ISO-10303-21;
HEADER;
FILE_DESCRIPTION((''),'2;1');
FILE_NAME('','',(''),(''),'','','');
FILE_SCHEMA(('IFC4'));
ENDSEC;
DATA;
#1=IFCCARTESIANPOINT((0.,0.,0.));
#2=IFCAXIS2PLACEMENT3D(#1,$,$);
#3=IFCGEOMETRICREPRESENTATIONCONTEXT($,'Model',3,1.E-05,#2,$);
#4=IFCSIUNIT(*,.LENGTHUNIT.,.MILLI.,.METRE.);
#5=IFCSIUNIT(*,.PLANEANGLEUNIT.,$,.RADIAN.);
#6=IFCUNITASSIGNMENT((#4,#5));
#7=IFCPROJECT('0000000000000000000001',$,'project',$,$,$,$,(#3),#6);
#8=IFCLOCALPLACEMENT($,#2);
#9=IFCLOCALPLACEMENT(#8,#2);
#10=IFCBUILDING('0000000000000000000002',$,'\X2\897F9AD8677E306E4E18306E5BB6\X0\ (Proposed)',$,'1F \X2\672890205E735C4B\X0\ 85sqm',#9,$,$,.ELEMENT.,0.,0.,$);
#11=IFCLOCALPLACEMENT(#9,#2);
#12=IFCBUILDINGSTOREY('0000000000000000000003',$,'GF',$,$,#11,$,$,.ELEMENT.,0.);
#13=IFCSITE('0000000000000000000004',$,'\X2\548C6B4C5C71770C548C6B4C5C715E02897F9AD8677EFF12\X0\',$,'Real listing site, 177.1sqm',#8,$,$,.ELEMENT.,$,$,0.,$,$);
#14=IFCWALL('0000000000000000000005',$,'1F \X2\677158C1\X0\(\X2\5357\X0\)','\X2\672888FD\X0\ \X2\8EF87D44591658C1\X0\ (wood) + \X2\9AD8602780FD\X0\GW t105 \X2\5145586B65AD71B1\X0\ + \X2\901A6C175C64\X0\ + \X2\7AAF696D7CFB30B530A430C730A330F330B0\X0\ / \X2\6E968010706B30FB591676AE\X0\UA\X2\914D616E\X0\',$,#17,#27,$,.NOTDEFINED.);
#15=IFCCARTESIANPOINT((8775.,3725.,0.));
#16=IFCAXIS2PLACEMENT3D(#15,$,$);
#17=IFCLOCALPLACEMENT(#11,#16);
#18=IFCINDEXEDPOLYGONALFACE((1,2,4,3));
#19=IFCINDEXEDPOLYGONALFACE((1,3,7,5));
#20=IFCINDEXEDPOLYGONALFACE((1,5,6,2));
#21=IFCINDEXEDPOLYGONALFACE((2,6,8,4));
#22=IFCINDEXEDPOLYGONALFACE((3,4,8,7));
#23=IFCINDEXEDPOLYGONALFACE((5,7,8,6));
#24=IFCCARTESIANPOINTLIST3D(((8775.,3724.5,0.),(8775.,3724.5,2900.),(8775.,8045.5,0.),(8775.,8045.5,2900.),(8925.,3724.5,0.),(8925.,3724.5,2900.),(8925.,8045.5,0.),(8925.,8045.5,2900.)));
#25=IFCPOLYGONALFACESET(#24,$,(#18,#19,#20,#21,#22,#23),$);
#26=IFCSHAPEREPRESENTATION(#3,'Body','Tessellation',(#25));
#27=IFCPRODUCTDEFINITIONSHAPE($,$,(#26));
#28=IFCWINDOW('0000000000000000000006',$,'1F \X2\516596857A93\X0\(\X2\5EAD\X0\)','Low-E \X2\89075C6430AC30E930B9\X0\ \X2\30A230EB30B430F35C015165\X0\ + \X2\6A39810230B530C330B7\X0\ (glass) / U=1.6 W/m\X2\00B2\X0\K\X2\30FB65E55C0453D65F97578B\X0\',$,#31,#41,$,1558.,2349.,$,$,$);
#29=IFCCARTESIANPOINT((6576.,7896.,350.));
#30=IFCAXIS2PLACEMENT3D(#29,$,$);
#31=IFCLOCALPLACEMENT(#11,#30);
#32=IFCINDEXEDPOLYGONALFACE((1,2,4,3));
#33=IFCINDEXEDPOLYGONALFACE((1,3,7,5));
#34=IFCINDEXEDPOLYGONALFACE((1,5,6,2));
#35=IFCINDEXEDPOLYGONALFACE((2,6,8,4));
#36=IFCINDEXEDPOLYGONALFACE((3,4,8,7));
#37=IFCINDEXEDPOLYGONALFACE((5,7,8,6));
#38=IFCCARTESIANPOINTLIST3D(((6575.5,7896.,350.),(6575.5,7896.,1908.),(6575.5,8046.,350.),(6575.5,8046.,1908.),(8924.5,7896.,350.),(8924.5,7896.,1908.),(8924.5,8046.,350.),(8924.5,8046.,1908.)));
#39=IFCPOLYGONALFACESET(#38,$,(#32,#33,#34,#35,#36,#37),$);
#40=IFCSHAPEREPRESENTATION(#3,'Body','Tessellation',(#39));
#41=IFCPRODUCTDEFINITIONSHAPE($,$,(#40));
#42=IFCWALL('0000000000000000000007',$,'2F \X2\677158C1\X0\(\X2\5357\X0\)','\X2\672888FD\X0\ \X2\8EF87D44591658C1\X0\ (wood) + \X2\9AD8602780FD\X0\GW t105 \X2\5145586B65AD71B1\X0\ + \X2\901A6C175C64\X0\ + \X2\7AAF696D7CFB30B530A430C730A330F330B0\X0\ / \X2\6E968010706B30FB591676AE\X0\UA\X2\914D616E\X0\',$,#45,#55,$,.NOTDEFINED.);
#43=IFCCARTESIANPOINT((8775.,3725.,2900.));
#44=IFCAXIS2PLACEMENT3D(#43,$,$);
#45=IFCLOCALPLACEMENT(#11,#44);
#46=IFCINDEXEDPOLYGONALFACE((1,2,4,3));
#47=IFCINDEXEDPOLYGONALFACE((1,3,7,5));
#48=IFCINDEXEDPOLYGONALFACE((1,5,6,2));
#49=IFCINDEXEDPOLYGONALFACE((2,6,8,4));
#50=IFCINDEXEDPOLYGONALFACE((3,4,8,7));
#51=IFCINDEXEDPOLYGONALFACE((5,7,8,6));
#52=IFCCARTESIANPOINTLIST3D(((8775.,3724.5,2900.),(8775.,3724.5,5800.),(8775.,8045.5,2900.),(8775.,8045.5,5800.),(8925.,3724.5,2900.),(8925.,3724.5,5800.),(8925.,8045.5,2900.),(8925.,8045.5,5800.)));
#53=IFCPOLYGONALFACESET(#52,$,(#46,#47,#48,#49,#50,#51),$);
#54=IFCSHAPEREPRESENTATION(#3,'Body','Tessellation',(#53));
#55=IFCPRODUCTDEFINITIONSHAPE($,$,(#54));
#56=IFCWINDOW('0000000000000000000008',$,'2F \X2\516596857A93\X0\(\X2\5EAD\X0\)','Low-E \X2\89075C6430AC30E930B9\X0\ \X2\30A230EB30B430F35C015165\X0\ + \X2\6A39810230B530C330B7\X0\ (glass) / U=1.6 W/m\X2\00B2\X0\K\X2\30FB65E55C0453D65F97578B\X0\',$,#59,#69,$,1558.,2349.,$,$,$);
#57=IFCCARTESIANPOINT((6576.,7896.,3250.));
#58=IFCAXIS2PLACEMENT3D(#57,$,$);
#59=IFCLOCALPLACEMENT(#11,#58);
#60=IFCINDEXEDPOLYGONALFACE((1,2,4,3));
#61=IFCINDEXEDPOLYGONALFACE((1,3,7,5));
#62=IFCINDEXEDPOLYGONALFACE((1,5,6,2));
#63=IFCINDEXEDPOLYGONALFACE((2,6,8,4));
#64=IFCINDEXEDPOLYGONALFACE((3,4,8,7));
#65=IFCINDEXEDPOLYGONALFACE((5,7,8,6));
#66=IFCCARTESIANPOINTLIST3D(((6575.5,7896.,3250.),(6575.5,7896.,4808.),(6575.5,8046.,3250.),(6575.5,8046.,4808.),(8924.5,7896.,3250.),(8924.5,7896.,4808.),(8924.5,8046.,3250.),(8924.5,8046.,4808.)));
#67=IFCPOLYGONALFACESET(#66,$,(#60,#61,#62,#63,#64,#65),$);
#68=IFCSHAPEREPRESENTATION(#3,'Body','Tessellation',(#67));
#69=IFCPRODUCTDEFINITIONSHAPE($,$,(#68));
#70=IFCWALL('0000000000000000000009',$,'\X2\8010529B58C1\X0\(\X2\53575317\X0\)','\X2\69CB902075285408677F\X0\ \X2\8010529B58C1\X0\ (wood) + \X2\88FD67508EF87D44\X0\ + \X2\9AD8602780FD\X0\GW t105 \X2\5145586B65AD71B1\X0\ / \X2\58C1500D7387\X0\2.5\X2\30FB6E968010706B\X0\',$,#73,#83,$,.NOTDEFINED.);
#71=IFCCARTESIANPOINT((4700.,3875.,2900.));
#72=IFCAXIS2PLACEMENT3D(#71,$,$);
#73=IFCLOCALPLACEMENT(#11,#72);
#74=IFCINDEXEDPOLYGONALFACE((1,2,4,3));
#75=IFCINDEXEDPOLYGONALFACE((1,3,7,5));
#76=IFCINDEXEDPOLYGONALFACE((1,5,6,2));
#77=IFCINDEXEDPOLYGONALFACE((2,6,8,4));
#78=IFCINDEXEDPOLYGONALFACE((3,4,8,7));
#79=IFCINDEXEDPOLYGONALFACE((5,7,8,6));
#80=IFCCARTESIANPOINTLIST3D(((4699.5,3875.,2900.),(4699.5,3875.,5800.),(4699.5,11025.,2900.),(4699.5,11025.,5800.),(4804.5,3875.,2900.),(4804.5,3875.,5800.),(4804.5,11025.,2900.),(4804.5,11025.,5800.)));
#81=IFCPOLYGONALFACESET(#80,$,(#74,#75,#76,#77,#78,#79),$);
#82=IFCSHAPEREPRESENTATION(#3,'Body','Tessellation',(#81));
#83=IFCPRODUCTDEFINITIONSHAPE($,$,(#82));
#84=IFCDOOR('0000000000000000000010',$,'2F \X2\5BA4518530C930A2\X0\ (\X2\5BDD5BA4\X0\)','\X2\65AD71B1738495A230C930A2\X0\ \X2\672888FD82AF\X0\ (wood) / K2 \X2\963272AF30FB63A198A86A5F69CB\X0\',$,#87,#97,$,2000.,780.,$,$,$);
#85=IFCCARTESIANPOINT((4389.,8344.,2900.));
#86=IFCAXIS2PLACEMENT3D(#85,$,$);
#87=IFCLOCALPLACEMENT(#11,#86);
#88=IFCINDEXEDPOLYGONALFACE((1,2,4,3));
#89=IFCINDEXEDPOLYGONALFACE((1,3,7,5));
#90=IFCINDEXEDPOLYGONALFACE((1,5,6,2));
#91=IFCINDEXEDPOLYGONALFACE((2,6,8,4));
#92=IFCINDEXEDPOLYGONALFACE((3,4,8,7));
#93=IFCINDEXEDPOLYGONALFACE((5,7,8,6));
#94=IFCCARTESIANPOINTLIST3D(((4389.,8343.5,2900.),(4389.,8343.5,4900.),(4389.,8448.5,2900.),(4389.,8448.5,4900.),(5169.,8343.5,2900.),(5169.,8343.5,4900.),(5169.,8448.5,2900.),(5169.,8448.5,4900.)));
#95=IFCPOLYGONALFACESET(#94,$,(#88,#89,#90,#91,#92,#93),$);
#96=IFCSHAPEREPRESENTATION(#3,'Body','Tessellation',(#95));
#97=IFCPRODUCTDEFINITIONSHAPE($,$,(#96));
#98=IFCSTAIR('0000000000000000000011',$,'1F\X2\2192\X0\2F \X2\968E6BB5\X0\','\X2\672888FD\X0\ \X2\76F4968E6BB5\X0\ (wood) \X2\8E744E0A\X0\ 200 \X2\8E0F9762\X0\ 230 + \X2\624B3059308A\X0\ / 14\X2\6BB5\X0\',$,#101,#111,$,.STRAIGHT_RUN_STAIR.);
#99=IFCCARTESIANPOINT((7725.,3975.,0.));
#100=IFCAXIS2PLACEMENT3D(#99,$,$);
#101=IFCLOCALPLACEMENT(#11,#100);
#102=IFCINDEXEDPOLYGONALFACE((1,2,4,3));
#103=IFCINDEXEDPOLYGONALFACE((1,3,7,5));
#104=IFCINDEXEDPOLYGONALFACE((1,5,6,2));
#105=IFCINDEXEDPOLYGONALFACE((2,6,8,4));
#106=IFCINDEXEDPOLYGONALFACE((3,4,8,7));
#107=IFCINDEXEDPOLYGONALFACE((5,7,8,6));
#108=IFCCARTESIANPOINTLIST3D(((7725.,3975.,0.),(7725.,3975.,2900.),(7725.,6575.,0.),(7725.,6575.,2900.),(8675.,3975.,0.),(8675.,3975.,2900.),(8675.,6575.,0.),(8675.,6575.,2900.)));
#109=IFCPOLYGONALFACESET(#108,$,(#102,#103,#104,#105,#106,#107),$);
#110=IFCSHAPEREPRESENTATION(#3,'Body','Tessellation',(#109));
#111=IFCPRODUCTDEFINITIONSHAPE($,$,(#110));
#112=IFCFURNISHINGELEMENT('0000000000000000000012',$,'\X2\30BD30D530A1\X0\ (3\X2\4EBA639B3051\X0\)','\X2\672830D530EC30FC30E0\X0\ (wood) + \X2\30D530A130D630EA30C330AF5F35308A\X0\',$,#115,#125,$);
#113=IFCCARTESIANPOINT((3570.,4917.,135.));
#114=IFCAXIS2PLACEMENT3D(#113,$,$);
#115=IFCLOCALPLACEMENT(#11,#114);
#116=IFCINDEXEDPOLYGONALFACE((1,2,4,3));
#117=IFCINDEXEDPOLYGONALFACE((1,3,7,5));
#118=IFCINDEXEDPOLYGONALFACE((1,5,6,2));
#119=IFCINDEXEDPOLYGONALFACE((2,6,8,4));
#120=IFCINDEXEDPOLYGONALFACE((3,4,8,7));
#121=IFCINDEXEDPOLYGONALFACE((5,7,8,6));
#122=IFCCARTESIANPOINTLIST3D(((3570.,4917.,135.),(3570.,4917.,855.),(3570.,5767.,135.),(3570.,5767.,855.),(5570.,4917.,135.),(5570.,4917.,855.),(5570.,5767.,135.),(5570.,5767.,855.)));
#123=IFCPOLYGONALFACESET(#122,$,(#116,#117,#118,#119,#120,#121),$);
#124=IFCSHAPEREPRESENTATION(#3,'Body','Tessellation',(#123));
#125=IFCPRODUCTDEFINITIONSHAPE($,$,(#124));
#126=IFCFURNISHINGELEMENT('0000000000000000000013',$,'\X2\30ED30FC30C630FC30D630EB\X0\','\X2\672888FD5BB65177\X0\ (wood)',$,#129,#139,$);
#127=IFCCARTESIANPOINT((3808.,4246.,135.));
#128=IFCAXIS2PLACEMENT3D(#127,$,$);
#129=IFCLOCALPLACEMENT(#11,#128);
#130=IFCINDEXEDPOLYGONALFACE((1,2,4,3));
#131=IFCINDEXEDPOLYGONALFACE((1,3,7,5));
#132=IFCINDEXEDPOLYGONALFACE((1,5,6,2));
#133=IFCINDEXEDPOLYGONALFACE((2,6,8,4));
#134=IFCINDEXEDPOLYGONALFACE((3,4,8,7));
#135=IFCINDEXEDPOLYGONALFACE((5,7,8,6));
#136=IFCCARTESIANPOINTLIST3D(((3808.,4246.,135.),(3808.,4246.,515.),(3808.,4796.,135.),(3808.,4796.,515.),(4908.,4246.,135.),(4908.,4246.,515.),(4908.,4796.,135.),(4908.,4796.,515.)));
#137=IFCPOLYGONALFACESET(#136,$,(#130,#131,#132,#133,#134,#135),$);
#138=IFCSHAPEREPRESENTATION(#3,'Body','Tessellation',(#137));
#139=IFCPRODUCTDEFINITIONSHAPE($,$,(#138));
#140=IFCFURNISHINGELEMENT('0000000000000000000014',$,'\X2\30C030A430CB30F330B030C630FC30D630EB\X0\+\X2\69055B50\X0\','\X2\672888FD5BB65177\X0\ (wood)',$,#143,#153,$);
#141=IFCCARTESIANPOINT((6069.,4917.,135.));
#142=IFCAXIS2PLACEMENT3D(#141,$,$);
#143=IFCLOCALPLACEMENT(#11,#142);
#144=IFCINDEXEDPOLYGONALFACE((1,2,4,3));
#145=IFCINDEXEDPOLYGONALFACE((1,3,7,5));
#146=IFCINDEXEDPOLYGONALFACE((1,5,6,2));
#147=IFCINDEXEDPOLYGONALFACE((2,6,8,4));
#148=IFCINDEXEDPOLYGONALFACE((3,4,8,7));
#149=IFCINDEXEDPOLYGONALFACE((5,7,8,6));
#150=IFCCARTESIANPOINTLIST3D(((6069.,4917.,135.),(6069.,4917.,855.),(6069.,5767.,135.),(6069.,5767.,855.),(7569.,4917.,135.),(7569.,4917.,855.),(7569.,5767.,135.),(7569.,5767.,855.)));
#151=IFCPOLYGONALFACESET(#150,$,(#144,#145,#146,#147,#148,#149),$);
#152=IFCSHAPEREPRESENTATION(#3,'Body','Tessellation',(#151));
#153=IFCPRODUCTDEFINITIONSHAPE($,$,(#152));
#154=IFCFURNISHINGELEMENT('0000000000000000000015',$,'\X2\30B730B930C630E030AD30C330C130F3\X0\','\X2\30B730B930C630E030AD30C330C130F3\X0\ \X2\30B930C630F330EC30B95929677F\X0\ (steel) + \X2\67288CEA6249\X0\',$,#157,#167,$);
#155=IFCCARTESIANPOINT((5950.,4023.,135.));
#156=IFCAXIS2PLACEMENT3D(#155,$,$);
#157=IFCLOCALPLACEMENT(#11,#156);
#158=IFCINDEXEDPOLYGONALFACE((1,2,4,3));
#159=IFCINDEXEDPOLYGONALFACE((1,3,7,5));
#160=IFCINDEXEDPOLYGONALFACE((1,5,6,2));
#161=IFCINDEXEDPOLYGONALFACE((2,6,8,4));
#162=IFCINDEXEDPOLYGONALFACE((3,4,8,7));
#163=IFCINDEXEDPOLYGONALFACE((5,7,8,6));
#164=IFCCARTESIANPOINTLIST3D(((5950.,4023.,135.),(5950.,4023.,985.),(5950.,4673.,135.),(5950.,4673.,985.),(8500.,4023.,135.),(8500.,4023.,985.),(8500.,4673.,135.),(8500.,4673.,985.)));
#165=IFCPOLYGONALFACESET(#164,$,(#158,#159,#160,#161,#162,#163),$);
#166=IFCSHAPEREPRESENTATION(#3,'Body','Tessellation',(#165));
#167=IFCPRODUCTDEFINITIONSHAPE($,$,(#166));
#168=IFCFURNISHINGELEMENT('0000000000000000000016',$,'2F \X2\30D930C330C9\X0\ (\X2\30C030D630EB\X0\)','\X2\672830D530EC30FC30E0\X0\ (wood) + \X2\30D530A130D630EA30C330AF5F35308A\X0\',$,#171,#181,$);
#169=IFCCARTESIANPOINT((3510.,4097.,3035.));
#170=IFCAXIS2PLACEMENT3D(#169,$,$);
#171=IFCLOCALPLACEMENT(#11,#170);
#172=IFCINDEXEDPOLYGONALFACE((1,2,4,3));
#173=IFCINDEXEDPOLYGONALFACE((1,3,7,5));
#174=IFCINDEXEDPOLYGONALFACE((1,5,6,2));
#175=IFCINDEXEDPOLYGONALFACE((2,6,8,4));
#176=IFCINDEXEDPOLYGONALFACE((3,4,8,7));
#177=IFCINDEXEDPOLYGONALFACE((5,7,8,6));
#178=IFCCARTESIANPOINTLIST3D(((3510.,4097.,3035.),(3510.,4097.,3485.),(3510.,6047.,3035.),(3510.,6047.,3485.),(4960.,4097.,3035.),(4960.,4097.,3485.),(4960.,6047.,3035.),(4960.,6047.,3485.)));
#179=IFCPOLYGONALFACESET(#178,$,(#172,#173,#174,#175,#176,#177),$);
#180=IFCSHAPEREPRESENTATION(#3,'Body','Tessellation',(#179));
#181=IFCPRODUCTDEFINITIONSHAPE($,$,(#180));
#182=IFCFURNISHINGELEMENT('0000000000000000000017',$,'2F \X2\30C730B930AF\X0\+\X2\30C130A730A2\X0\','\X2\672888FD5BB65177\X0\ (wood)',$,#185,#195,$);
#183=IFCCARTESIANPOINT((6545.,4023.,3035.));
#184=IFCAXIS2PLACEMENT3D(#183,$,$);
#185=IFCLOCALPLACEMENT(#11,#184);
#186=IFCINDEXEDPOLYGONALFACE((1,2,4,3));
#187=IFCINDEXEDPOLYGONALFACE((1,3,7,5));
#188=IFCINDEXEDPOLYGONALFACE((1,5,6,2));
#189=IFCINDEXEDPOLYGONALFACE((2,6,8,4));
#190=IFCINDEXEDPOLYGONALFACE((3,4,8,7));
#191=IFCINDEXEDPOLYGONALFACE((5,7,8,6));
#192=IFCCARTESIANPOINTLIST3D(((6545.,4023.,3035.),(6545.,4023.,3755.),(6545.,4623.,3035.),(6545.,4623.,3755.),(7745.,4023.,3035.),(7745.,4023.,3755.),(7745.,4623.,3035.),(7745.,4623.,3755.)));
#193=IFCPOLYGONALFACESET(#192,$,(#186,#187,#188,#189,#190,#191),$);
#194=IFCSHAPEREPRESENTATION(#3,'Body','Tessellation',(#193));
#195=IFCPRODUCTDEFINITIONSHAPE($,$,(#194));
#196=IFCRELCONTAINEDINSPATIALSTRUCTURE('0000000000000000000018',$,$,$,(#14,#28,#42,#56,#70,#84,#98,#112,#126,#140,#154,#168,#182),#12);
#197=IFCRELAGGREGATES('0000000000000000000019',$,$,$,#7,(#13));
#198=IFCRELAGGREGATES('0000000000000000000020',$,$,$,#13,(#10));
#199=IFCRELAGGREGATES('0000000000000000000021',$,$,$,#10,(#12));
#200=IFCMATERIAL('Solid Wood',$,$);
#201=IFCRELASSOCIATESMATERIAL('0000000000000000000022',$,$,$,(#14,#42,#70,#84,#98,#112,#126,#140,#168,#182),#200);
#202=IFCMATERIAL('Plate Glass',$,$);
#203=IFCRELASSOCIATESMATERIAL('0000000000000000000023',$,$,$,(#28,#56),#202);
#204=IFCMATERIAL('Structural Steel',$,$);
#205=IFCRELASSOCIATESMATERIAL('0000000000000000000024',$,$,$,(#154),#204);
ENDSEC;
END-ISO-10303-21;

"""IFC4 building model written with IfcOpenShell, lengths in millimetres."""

from ifc_helpers import new_model, si_unit, frame, frame_2d, origin, place, context, project, spatial, rectangle, extrude, material, element, fill, save


model = new_model("IFC4")

# Units and contexts
model_context = context("Model", 3, precision=1e-05, world=origin())
ifc_project = project(units=[si_unit("LENGTHUNIT", "METRE", prefix="MILLI"), si_unit("PLANEANGLEUNIT", "RADIAN")], contexts=[model_context])

# Site, building, storey
site_placement = place(None, origin())
site = spatial("IfcSite", under=ifc_project, at=site_placement, Name="和歌山県和歌山市西高松２", ObjectType="Real listing site, 177.1sqm", CompositionType="ELEMENT", RefElevation=0.0)
building_placement = place(site_placement, origin())
building = spatial("IfcBuilding", under=site, at=building_placement, Name="西高松の丘の家 (Proposed)", ObjectType="1F 木造平屋 85sqm", CompositionType="ELEMENT", ElevationOfRefHeight=0.0, ElevationOfTerrain=0.0)
storey_placement = place(building_placement, origin())
storey = spatial("IfcBuildingStorey", under=building, at=storey_placement, Name="GF", CompositionType="ELEMENT", Elevation=0.0)

# Wall, opening, window
ifc_material_1 = material(Name="Solid Wood")
wall_1_placement = place(storey_placement, frame((8775.0, 3725.0, 0.0)))
wall_1 = element("IfcWall", 1, at=wall_1_placement, inside=storey, material=ifc_material_1, Name="1F 東壁(南)", Description="木製 軸組外壁 (wood) + 高性能GW t105 充填断熱 + 通気層 + 窯業系サイディング / 準耐火・外皮UA配慮", PredefinedType="NOTDEFINED", context=model_context, shape_type="SweptSolid", body=[
    extrude(rectangle(XDim=150.0, YDim=4321.0, at=frame_2d((75.0, 2160.0))), frame((8775.0, 3725.0, 0.0)), (0.0, 0.0, 1.0), 2900.0),
])
opening_1_placement = place(storey_placement, frame((6576.0, 7896.0, 350.0)))
opening_1 = element("IfcOpeningElement", 2, at=opening_1_placement, cuts=wall_1, PredefinedType="NOTDEFINED", context=model_context, shape_type="SweptSolid", body=[
    extrude(rectangle(XDim=2349.0, YDim=150.0, at=frame_2d((1174.0, 75.0))), frame((6576.0, 7896.0, 350.0)), (0.0, 0.0, 1.0), 1558.0),
])
ifc_material_2 = material(Name="Plate Glass")
window_1_placement = place(storey_placement, frame((6576.0, 7896.0, 350.0)))
window_1 = element("IfcWindow", 3, at=window_1_placement, inside=storey, material=ifc_material_2, Name="1F 入隅窓(庭)", Description="Low-E 複層ガラス アルゴン封入 + 樹脂サッシ (glass) / U=1.6 W/m²K・日射取得型", OverallHeight=1558.0, OverallWidth=2349.0, context=model_context, shape_type="SweptSolid", body=[
    extrude(rectangle(XDim=2349.0, YDim=150.0, at=frame_2d((1174.0, 75.0))), frame((6576.0, 7896.0, 350.0)), (0.0, 0.0, 1.0), 1558.0),
])
fill(opening_1, window_1)

# Wall, opening, window
wall_2_placement = place(storey_placement, frame((8775.0, 3725.0, 2900.0)))
wall_2 = element("IfcWall", 4, at=wall_2_placement, inside=storey, material=ifc_material_1, Name="2F 東壁(南)", Description="木製 軸組外壁 (wood) + 高性能GW t105 充填断熱 + 通気層 + 窯業系サイディング / 準耐火・外皮UA配慮", PredefinedType="NOTDEFINED", context=model_context, shape_type="SweptSolid", body=[
    extrude(rectangle(XDim=150.0, YDim=4321.0, at=frame_2d((75.0, 2160.0))), frame((8775.0, 3725.0, 2900.0)), (0.0, 0.0, 1.0), 2900.0),
])
opening_2_placement = place(storey_placement, frame((6576.0, 7896.0, 3250.0)))
opening_2 = element("IfcOpeningElement", 5, at=opening_2_placement, cuts=wall_2, PredefinedType="NOTDEFINED", context=model_context, shape_type="SweptSolid", body=[
    extrude(rectangle(XDim=2349.0, YDim=150.0, at=frame_2d((1174.0, 75.0))), frame((6576.0, 7896.0, 3250.0)), (0.0, 0.0, 1.0), 1558.0),
])
window_2_placement = place(storey_placement, frame((6576.0, 7896.0, 3250.0)))
window_2 = element("IfcWindow", 6, at=window_2_placement, inside=storey, material=ifc_material_2, Name="2F 入隅窓(庭)", Description="Low-E 複層ガラス アルゴン封入 + 樹脂サッシ (glass) / U=1.6 W/m²K・日射取得型", OverallHeight=1558.0, OverallWidth=2349.0, context=model_context, shape_type="SweptSolid", body=[
    extrude(rectangle(XDim=2349.0, YDim=150.0, at=frame_2d((1174.0, 75.0))), frame((6576.0, 7896.0, 3250.0)), (0.0, 0.0, 1.0), 1558.0),
])
fill(opening_2, window_2)

# Wall, opening, door
wall_3_placement = place(storey_placement, frame((4700.0, 3875.0, 2900.0)))
wall_3 = element("IfcWall", 7, at=wall_3_placement, inside=storey, material=ifc_material_1, Name="耐力壁(南北)", Description="構造用合板 耐力壁 (wood) + 製材軸組 + 高性能GW t105 充填断熱 / 壁倍率2.5・準耐火", PredefinedType="NOTDEFINED", context=model_context, shape_type="SweptSolid", body=[
    extrude(rectangle(XDim=105.0, YDim=7150.0, at=frame_2d((52.0, 3575.0))), frame((4700.0, 3875.0, 2900.0)), (0.0, 0.0, 1.0), 2900.0),
])
opening_3_placement = place(storey_placement, frame((4389.0, 8344.0, 2900.0)))
opening_3 = element("IfcOpeningElement", 8, at=opening_3_placement, cuts=wall_3, PredefinedType="NOTDEFINED", context=model_context, shape_type="SweptSolid", body=[
    extrude(rectangle(XDim=780.0, YDim=105.0, at=frame_2d((390.0, 52.0))), frame((4389.0, 8344.0, 2900.0)), (0.0, 0.0, 1.0), 2000.0),
])
door_1_placement = place(storey_placement, frame((4389.0, 8344.0, 2900.0)))
door_1 = element("IfcDoor", 9, at=door_1_placement, inside=storey, material=ifc_material_1, Name="2F 室内ドア (寝室)", Description="断熱玄関ドア 木製芯 (wood) / K2 防犯・採風機構", OverallHeight=2000.0, OverallWidth=780.0, context=model_context, shape_type="SweptSolid", body=[
    extrude(rectangle(XDim=780.0, YDim=105.0, at=frame_2d((390.0, 52.0))), frame((4389.0, 8344.0, 2900.0)), (0.0, 0.0, 1.0), 2000.0),
])
fill(opening_3, door_1)

# Stair
stair_placement = place(storey_placement, frame((7725.0, 3975.0, 0.0)))
element("IfcStair", 10, at=stair_placement, inside=storey, material=ifc_material_1, Name="1F→2F 階段", Description="木製 直階段 (wood) 蹴上 200 踏面 230 + 手すり / 14段", PredefinedType="STRAIGHT_RUN_STAIR", context=model_context, shape_type="SweptSolid", body=[
    extrude(rectangle(XDim=950.0, YDim=2600.0, at=frame_2d((475.0, 1300.0))), frame((7725.0, 3975.0, 0.0)), (0.0, 0.0, 1.0), 2900.0),
])

# Furnishing elements
furnishing_1_placement = place(storey_placement, frame((3570.0, 4917.0, 135.0)))
element("IfcFurnishingElement", 11, at=furnishing_1_placement, inside=storey, material=ifc_material_1, Name="ソファ (3人掛け)", Description="木フレーム (wood) + ファブリック張り", context=model_context, shape_type="SweptSolid", body=[
    extrude(rectangle(XDim=2000.0, YDim=850.0, at=frame_2d((1000.0, 425.0))), frame((3570.0, 4917.0, 135.0)), (0.0, 0.0, 1.0), 720.0),
])
furnishing_2_placement = place(storey_placement, frame((3808.0, 4246.0, 135.0)))
element("IfcFurnishingElement", 12, at=furnishing_2_placement, inside=storey, material=ifc_material_1, Name="ローテーブル", Description="木製家具 (wood)", context=model_context, shape_type="SweptSolid", body=[
    extrude(rectangle(XDim=1100.0, YDim=550.0, at=frame_2d((550.0, 275.0))), frame((3808.0, 4246.0, 135.0)), (0.0, 0.0, 1.0), 380.0),
])
furnishing_3_placement = place(storey_placement, frame((6069.0, 4917.0, 135.0)))
element("IfcFurnishingElement", 13, at=furnishing_3_placement, inside=storey, material=ifc_material_1, Name="ダイニングテーブル+椅子", Description="木製家具 (wood)", context=model_context, shape_type="SweptSolid", body=[
    extrude(rectangle(XDim=1500.0, YDim=850.0, at=frame_2d((750.0, 425.0))), frame((6069.0, 4917.0, 135.0)), (0.0, 0.0, 1.0), 720.0),
])
ifc_material_3 = material(Name="Structural Steel")
furnishing_4_placement = place(storey_placement, frame((5950.0, 4023.0, 135.0)))
element("IfcFurnishingElement", 14, at=furnishing_4_placement, inside=storey, material=ifc_material_3, Name="システムキッチン", Description="システムキッチン ステンレス天板 (steel) + 木質扉", context=model_context, shape_type="SweptSolid", body=[
    extrude(rectangle(XDim=2550.0, YDim=650.0, at=frame_2d((1275.0, 325.0))), frame((5950.0, 4023.0, 135.0)), (0.0, 0.0, 1.0), 850.0),
])
furnishing_5_placement = place(storey_placement, frame((3510.0, 4097.0, 3035.0)))
element("IfcFurnishingElement", 15, at=furnishing_5_placement, inside=storey, material=ifc_material_1, Name="2F ベッド (ダブル)", Description="木フレーム (wood) + ファブリック張り", context=model_context, shape_type="SweptSolid", body=[
    extrude(rectangle(XDim=1450.0, YDim=1950.0, at=frame_2d((725.0, 975.0))), frame((3510.0, 4097.0, 3035.0)), (0.0, 0.0, 1.0), 450.0),
])
furnishing_6_placement = place(storey_placement, frame((6545.0, 4023.0, 3035.0)))
element("IfcFurnishingElement", 16, at=furnishing_6_placement, inside=storey, material=ifc_material_1, Name="2F デスク+チェア", Description="木製家具 (wood)", context=model_context, shape_type="SweptSolid", body=[
    extrude(rectangle(XDim=1200.0, YDim=600.0, at=frame_2d((600.0, 300.0))), frame((6545.0, 4023.0, 3035.0)), (0.0, 0.0, 1.0), 720.0),
])

save(model, "model.ifc")
